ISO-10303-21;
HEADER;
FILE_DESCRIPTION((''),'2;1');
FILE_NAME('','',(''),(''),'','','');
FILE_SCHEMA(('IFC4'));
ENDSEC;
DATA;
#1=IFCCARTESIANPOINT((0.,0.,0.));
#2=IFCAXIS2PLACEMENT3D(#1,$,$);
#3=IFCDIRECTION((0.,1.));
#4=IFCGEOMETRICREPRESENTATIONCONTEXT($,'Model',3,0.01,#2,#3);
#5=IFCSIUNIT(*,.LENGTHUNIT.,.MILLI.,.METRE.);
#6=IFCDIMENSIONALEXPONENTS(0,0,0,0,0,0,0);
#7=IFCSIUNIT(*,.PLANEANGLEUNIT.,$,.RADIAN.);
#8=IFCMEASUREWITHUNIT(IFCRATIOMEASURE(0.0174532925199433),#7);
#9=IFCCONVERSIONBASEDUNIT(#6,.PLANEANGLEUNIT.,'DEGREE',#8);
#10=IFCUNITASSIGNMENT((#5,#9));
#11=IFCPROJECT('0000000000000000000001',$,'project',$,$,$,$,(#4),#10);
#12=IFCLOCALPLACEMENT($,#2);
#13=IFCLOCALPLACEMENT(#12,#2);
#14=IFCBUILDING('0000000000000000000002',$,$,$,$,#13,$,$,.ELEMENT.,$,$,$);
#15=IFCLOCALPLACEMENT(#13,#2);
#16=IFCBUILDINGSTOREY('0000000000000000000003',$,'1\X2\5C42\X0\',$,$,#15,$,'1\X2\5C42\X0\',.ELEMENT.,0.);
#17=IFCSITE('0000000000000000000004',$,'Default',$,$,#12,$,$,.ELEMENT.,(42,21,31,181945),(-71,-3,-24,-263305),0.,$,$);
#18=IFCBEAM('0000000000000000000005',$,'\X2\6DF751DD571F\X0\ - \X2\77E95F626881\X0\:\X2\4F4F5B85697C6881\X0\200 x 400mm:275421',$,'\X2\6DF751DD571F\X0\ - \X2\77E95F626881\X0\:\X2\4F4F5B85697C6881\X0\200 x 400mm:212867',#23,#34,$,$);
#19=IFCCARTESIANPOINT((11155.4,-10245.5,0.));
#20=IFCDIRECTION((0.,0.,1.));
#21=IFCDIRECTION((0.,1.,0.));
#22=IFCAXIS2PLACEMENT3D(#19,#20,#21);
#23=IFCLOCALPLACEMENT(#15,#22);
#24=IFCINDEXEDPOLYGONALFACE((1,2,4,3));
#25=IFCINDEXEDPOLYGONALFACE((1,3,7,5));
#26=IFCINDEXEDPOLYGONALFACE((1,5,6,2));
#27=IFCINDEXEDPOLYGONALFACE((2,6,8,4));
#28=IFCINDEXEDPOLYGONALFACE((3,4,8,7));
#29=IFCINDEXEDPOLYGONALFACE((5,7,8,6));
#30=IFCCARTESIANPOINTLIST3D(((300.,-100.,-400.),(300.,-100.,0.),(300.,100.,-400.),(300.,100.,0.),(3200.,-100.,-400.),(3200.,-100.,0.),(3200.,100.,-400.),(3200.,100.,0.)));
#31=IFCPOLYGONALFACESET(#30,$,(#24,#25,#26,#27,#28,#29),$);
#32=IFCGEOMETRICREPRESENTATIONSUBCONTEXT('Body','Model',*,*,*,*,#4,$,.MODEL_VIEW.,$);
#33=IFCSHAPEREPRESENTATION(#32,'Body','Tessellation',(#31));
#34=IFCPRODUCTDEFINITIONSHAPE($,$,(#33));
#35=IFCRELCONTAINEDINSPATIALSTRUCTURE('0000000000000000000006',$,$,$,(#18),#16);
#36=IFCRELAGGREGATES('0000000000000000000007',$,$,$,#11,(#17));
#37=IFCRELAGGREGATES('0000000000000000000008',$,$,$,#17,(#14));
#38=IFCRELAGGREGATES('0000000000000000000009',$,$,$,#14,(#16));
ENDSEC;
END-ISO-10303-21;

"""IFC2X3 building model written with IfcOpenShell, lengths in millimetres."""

from ifc_helpers import new_model, entity, si_unit, converted_unit, direction, frame, frame_2d, origin, place, context, subcontext, project, spatial, rectangle, extrude, element, save


model = new_model("IFC2X3")

# Units and contexts
model_context = context("Model", 3, precision=0.01, world=origin(), true_north=direction((0.0, 1.0)))
body_context = subcontext(model_context, "Body", "Model", "MODEL_VIEW")
ifc_project = project(units=[si_unit("LENGTHUNIT", "METRE", prefix="MILLI"), converted_unit("PLANEANGLEUNIT", "DEGREE", entity("IfcRatioMeasure", 0.0174532925199433), si_unit("PLANEANGLEUNIT", "RADIAN"), dimensions=[0, 0, 0, 0, 0, 0, 0])], contexts=[model_context])

# Site, building, storey
site_placement = place(None, origin())
site = spatial("IfcSite", under=ifc_project, at=site_placement, Name="Default", CompositionType="ELEMENT", RefLatitude=(42, 21, 31, 181945), RefLongitude=(-71, -3, -24, -263305), RefElevation=0.0)
building_placement = place(site_placement, origin())
building = spatial("IfcBuilding", under=site, at=building_placement, CompositionType="ELEMENT")
storey_placement = place(building_placement, origin())
storey = spatial("IfcBuildingStorey", under=building, at=storey_placement, Name="1层", LongName="1层", CompositionType="ELEMENT", Elevation=0.0)

# Beam
beam_1_placement = place(storey_placement, frame((11155.4, -10245.5, 0.0), z_axis=(0.0, 0.0, 1.0), x_axis=(0.0, 1.0, 0.0)))
element("IfcBeam", 1, at=beam_1_placement, inside=storey, Name="混凝土 - 矩形梁:住宅楼梁200 x 400mm:275421", ObjectType="混凝土 - 矩形梁:住宅楼梁200 x 400mm:212867", context=body_context, shape_type="SweptSolid", body=[
    extrude(rectangle(XDim=400.0, YDim=200.0, at=frame_2d((0.0, 0.0), x_axis=(1.0, 0.0))), frame((300.0, 0.0, -200.0), z_axis=(1.0, 0.0, 0.0), x_axis=(0.0, 0.0, -1.0)), (0.0, 0.0, 1.0), 2900.0),
])

save(model, "model.ifc")
